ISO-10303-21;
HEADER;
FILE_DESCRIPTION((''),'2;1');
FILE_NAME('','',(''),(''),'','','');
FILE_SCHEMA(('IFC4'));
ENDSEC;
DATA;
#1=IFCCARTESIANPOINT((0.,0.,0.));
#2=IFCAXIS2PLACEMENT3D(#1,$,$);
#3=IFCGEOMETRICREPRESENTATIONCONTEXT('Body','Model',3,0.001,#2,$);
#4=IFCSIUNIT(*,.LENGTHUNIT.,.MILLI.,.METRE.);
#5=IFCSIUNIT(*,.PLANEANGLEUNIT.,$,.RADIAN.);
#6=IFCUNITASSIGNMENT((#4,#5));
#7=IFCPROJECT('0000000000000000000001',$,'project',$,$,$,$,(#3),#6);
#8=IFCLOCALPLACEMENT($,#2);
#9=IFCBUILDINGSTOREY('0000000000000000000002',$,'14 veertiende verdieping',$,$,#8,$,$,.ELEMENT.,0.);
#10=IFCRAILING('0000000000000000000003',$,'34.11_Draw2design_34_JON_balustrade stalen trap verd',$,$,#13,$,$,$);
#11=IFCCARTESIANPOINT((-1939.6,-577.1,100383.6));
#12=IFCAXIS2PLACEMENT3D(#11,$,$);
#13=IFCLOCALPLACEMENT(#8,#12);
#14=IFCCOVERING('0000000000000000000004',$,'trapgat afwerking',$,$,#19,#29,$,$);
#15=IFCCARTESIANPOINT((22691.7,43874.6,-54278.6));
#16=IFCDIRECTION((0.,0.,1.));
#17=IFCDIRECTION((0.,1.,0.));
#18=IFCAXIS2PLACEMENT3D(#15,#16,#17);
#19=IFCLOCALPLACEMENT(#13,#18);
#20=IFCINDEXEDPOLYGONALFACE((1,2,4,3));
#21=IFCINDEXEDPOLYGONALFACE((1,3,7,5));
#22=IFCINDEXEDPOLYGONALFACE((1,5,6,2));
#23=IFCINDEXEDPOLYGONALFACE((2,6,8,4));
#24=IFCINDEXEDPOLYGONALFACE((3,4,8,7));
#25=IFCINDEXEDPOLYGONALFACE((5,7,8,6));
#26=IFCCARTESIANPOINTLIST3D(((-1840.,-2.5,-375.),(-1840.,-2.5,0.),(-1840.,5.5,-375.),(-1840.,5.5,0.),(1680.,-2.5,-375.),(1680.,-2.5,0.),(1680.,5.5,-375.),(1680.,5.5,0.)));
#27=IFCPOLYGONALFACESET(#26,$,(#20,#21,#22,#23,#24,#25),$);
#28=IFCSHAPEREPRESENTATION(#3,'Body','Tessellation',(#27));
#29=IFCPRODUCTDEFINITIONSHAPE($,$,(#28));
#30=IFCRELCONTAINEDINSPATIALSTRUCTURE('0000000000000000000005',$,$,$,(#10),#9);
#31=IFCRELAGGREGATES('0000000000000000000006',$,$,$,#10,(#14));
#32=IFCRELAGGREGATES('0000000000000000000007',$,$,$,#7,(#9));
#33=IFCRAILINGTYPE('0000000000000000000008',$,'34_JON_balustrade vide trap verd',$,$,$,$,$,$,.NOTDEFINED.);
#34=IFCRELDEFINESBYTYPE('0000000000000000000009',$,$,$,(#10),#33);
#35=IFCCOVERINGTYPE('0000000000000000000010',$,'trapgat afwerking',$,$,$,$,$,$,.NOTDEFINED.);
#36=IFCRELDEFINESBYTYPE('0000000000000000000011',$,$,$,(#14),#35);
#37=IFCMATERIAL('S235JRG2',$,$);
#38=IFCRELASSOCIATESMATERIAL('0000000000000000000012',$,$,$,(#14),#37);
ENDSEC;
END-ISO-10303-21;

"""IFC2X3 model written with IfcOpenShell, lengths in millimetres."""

from ifc_helpers import new_model, si_unit, frame, origin, place, context, project, spatial, polyline, outline, extrude, source, transform, mapped, material, type_object, element, aggregate, save


model = new_model("IFC2X3")

# Units and contexts
model_context = context("Model", 3, precision=0.001, world=origin(), identifier="Body")
ifc_project = project(units=[si_unit("LENGTHUNIT", "METRE", prefix="MILLI"), si_unit("PLANEANGLEUNIT", "RADIAN")], contexts=[model_context])

# Storey
storey_placement = place(None, origin())
storey = spatial("IfcBuildingStorey", under=ifc_project, at=storey_placement, Name="14 veertiende verdieping", CompositionType="ELEMENT", Elevation=0.0)

# Shared definitions
ifc_material_1 = material(Name="S235JRG2")

# Railing, covering
railing_type = type_object("IfcRailingType", Name="34_JON_balustrade vide trap verd")
railing_placement = place(storey_placement, frame((-1939.6, -577.1, 100383.6)))
railing = element("IfcRailing", 1, at=railing_placement, inside=storey, type_object=railing_type, Name="34.11_Draw2design_34_JON_balustrade stalen trap verd")
covering_type = type_object("IfcCoveringType", Name="trapgat afwerking")
shared_shape_1 = source(origin(), model_context, "Body", "SweptSolid", [
    extrude(outline(polyline([(-1840.0, -2.5), (1680.0, -2.5), (1680.0, 5.5), (-1840.0, 5.5), (-1840.0, -2.5)])), origin(), (0.0, 0.0, -1.0), 375.0),
])
covering_placement = place(railing_placement, frame((22691.7, 43874.6, -54278.6), z_axis=(0.0, 0.0, 1.0), x_axis=(0.0, 1.0, 0.0)))
covering = element("IfcCovering", 2, at=covering_placement, type_object=covering_type, material=ifc_material_1, Name="trapgat afwerking", context=model_context, shape_type="MappedRepresentation", body=[
    mapped(shared_shape_1, transform((0.0, 0.0, 0.0), scale=1.0)),
])
aggregate(railing, [covering])

save(model, "model.ifc")
